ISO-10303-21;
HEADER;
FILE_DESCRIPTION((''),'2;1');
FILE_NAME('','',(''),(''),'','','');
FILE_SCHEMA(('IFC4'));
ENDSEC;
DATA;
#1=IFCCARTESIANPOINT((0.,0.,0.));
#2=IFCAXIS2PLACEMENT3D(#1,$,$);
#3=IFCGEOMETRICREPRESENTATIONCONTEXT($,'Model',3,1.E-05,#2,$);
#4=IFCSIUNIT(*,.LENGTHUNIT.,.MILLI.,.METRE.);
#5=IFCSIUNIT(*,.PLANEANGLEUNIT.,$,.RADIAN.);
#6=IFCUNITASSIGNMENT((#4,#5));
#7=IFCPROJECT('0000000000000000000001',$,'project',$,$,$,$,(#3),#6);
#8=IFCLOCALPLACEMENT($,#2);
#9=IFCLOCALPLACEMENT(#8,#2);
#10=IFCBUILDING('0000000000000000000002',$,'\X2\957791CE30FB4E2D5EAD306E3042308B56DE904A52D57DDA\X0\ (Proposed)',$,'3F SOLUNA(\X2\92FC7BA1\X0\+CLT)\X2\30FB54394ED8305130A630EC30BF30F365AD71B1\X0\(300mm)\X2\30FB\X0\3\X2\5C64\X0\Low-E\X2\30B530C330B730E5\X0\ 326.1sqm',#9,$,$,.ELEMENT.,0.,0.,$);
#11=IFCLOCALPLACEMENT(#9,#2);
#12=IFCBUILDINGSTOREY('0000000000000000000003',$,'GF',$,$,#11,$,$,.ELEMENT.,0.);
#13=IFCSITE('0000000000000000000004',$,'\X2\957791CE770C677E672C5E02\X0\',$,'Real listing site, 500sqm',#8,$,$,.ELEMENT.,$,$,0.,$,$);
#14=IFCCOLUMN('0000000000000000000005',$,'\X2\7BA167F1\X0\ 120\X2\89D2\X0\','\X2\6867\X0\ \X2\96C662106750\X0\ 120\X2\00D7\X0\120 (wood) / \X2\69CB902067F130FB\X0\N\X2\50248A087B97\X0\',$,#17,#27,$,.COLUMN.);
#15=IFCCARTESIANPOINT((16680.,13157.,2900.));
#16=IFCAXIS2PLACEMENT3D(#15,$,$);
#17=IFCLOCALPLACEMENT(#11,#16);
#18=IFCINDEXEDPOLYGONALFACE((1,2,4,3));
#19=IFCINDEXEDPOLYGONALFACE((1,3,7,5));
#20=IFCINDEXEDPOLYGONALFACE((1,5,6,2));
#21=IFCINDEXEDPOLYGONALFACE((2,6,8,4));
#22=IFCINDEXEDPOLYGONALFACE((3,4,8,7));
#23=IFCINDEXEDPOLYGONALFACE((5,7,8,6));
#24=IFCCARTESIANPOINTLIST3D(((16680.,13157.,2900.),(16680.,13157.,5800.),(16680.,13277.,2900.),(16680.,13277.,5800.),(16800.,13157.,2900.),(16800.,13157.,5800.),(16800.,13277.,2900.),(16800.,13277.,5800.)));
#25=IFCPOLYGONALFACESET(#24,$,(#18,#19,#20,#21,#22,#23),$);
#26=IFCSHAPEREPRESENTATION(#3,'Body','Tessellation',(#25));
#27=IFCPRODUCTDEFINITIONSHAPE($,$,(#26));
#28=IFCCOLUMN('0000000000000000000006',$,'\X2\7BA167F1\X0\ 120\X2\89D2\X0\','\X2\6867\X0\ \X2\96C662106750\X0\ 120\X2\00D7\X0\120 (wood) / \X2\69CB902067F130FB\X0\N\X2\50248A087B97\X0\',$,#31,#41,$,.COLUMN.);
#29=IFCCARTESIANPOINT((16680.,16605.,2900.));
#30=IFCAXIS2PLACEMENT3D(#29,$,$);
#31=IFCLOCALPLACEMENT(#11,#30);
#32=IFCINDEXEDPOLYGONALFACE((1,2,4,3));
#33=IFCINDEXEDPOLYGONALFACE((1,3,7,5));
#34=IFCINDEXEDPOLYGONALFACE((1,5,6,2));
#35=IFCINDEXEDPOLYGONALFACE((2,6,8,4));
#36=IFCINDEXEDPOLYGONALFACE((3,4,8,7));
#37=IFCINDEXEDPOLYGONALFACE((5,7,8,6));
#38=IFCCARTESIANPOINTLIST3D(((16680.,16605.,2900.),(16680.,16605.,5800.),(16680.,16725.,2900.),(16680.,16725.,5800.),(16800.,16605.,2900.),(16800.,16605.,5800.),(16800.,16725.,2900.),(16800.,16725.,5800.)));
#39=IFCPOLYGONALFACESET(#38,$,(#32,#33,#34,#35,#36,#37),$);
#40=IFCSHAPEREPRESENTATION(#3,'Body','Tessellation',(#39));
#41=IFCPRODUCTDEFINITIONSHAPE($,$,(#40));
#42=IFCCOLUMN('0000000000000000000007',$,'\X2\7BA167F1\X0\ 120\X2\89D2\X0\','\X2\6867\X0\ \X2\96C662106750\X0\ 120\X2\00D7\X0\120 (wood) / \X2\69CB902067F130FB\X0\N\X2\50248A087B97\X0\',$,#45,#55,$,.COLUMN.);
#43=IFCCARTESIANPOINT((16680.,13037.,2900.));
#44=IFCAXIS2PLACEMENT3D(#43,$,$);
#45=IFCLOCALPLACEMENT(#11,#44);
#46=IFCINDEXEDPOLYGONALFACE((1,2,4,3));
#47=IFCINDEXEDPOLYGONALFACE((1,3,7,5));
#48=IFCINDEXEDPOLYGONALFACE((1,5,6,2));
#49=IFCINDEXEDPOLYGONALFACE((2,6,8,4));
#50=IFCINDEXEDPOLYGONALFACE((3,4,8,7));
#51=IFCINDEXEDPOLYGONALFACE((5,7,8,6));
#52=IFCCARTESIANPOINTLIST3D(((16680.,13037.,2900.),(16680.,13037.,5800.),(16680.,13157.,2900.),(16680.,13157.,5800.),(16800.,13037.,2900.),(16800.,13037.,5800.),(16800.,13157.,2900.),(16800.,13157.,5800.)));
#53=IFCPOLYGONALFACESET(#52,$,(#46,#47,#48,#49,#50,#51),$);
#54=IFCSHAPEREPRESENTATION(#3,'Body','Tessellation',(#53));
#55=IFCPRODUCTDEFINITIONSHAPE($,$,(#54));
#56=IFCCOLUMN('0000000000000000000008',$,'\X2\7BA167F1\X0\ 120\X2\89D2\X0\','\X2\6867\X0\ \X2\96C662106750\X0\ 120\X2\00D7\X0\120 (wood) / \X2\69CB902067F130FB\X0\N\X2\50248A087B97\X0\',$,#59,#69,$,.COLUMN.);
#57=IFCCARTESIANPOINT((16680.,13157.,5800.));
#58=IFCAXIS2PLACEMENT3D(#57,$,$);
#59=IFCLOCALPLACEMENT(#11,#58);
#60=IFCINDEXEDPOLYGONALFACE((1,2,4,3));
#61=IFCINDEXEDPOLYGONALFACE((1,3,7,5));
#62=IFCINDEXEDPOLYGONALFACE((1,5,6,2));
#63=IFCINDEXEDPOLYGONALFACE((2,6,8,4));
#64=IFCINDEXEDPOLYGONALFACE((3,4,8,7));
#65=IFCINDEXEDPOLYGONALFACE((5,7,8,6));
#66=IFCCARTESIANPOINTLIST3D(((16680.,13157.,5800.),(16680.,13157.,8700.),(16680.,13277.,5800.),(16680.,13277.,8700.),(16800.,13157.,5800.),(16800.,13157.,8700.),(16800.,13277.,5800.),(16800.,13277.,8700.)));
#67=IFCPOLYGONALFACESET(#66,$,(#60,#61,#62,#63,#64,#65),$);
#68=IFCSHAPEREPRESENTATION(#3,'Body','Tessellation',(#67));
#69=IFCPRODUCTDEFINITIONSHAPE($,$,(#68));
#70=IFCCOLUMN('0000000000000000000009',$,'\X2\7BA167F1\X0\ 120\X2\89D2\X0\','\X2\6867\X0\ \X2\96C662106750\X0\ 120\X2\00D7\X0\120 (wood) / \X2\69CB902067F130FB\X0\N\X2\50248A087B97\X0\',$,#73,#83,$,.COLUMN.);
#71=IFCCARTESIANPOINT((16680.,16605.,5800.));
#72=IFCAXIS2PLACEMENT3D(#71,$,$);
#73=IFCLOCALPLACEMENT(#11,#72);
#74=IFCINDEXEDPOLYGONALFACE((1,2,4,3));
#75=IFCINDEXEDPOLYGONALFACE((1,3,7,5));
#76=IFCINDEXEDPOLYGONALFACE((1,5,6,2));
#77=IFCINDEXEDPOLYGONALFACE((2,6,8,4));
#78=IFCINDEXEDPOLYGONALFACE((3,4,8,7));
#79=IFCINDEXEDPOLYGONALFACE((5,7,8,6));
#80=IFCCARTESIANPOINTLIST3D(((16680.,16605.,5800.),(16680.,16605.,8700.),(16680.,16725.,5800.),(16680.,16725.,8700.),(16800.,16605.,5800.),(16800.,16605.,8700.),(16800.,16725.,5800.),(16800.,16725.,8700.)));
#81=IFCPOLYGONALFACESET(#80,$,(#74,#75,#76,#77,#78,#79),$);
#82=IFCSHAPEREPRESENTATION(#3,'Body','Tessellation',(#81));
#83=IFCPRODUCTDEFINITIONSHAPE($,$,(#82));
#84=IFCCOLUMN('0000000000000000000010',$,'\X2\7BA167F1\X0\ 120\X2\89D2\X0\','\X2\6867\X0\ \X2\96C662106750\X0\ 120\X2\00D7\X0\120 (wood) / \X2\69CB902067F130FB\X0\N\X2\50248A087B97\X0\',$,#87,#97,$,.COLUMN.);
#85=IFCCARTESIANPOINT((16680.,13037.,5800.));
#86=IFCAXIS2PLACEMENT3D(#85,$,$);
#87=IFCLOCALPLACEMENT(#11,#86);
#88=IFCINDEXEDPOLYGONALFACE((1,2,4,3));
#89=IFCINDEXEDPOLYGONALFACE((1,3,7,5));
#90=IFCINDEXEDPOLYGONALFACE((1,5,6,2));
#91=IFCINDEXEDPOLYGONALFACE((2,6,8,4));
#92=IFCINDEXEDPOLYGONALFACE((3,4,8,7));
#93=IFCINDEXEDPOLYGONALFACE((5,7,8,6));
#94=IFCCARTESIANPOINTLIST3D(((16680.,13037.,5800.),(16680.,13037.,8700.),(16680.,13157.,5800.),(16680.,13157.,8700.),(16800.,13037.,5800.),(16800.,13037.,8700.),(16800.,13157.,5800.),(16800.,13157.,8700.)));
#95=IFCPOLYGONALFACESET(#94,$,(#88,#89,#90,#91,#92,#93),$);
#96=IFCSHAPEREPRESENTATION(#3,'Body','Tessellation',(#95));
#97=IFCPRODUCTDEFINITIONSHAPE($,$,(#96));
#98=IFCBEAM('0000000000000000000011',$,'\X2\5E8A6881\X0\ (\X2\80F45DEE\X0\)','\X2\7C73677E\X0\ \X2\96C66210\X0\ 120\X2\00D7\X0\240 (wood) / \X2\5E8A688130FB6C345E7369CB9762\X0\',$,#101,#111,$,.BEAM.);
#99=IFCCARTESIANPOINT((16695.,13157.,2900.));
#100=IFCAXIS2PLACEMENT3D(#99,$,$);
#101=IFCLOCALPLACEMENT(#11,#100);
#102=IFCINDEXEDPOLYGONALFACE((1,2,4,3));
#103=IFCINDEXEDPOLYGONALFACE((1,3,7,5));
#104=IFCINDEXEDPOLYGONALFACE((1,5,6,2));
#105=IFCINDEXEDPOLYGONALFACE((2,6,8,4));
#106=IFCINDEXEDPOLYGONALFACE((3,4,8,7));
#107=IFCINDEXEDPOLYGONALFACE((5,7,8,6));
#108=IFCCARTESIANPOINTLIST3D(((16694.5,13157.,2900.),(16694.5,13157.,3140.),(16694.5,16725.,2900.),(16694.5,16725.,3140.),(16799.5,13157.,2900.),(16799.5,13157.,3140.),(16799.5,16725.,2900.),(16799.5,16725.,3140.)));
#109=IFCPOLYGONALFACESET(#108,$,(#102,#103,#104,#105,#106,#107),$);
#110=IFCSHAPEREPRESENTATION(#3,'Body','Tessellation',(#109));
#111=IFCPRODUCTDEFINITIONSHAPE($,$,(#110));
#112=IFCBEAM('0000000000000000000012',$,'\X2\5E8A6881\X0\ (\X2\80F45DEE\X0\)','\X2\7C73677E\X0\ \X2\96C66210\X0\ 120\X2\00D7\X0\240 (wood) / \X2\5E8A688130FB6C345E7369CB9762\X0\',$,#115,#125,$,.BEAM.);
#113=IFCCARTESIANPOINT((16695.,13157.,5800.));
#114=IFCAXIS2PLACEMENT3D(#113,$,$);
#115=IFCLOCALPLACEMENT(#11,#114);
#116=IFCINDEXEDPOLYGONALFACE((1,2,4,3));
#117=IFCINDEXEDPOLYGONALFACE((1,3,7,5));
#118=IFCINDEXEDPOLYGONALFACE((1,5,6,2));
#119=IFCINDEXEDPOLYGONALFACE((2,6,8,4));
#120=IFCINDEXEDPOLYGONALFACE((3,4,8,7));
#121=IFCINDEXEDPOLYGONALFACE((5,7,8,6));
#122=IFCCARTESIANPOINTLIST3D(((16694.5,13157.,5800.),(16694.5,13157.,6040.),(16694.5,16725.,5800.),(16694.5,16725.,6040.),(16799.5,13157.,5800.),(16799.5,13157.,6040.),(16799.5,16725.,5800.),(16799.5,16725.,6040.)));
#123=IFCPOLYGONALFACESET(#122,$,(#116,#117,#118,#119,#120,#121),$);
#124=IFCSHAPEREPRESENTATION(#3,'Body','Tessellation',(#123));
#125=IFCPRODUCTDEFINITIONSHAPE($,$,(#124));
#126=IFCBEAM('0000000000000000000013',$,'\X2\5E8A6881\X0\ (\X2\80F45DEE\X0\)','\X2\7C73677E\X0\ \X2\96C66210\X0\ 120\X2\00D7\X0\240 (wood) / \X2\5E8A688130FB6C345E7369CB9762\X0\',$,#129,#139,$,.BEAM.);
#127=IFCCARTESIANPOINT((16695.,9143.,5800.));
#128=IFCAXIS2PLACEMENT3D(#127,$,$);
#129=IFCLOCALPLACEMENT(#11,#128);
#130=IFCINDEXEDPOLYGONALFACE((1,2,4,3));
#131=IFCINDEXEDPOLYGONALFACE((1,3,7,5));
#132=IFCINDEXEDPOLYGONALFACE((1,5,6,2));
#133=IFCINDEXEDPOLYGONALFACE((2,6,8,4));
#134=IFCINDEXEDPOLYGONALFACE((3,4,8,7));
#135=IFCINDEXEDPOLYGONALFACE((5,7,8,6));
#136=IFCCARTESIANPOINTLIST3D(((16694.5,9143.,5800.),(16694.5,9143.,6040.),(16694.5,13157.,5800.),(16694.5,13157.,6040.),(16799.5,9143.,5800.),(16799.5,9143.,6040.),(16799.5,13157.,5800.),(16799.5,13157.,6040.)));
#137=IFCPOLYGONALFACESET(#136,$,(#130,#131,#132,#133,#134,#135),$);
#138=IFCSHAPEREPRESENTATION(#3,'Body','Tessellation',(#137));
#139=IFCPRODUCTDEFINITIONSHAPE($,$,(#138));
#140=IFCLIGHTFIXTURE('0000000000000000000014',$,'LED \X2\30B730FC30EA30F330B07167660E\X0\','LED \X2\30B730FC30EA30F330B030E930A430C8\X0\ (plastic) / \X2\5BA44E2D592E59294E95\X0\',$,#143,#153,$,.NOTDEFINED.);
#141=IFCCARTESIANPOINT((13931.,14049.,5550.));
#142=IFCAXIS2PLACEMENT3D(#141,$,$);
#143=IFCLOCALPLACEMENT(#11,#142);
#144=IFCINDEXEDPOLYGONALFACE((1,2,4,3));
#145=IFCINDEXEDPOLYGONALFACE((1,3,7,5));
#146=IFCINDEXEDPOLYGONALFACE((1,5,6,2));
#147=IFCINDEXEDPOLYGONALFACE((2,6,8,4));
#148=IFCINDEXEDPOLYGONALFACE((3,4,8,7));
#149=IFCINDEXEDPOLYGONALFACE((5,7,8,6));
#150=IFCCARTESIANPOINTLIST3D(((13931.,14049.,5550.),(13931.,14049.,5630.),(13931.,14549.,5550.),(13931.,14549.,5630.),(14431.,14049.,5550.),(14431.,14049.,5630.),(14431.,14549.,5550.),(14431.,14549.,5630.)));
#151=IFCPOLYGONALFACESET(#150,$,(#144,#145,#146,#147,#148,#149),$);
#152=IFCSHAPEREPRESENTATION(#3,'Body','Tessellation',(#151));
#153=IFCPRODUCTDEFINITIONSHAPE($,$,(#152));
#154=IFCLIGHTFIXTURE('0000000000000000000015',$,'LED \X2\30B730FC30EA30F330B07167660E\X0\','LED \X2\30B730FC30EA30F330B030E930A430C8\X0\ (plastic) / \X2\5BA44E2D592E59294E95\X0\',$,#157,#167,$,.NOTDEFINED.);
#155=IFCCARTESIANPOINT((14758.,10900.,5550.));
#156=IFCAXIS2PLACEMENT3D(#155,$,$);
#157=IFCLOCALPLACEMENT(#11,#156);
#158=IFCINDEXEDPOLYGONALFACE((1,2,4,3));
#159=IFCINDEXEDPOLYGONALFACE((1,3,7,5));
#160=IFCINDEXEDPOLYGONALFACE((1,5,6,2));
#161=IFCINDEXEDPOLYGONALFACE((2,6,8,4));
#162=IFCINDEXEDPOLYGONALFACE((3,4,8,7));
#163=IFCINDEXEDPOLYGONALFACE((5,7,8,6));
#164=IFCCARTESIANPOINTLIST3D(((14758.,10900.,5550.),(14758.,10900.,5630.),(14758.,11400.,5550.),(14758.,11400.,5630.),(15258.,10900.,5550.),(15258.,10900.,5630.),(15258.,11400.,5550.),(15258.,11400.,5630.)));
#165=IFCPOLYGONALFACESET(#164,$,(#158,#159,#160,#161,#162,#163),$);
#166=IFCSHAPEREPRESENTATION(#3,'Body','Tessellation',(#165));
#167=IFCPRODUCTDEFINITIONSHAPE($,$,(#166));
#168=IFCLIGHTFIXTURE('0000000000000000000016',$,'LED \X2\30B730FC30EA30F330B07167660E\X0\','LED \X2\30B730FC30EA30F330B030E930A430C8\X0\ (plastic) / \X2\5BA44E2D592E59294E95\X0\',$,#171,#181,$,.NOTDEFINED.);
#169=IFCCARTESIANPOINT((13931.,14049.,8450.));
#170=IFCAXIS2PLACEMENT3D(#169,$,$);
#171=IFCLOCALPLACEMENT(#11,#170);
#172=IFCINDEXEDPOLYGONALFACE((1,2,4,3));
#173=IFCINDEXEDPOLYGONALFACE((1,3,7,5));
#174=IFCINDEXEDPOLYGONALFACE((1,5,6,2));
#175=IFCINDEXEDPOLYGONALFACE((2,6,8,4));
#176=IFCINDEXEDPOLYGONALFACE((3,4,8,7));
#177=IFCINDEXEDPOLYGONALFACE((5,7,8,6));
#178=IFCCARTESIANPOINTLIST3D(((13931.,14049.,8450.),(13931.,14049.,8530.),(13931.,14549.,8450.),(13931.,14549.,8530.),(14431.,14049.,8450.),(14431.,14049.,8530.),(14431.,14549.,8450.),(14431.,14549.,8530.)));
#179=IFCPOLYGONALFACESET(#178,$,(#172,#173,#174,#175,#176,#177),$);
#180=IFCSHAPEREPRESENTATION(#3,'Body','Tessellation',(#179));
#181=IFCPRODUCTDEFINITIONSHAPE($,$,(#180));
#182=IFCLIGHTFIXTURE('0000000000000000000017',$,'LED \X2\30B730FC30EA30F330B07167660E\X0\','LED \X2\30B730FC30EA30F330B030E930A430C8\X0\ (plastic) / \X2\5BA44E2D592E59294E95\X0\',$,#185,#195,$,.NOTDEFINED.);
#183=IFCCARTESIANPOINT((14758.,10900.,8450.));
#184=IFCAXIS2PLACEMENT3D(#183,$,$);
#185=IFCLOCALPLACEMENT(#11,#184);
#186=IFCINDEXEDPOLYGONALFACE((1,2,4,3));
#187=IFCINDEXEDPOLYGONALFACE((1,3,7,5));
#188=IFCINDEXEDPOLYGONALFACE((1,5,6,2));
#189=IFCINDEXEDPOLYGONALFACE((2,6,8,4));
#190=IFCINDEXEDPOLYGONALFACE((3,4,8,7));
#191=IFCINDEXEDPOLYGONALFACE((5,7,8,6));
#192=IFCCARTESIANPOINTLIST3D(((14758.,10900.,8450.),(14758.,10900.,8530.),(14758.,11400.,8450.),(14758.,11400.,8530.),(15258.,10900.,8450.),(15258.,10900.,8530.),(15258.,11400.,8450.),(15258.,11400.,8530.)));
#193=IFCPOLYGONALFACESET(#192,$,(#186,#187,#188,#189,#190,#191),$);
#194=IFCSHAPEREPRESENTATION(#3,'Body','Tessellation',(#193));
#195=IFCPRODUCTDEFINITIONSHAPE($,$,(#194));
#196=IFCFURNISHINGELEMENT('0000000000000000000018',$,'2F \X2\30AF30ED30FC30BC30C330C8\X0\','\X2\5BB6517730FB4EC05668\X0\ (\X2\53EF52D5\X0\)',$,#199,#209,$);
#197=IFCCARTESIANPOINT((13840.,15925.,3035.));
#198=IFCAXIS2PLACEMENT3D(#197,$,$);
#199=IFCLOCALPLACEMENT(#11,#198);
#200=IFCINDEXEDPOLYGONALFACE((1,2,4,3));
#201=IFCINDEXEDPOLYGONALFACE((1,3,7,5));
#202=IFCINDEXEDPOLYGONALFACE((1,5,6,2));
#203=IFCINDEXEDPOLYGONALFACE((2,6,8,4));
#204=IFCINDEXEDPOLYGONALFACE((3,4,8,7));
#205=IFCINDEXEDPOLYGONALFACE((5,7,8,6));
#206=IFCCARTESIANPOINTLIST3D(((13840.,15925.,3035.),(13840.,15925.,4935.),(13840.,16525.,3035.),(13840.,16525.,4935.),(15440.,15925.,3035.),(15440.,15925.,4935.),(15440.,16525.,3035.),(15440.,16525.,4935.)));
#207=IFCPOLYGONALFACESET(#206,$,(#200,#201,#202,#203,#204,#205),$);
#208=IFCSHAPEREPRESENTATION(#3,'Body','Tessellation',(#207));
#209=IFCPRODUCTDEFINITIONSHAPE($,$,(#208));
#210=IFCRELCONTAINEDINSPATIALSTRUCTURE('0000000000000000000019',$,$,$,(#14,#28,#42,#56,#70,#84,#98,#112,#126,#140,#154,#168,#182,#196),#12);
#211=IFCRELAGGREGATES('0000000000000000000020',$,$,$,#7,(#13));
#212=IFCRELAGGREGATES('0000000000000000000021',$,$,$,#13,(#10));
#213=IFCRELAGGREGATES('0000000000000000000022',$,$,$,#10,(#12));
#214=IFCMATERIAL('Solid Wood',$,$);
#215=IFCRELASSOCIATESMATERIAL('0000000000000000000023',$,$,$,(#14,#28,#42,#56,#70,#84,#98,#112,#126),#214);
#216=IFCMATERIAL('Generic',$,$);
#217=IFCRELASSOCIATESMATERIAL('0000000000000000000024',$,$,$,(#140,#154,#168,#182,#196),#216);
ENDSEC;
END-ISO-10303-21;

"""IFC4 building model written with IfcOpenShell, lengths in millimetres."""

from ifc_helpers import new_model, si_unit, frame, frame_2d, origin, place, context, project, spatial, rectangle, extrude, material, element, save


model = new_model("IFC4")

# Units and contexts
model_context = context("Model", 3, precision=1e-05, world=origin())
ifc_project = project(units=[si_unit("LENGTHUNIT", "METRE", prefix="MILLI"), si_unit("PLANEANGLEUNIT", "RADIAN")], contexts=[model_context])

# Site, building, storey
site_placement = place(None, origin())
site = spatial("IfcSite", under=ifc_project, at=site_placement, Name="長野県松本市", ObjectType="Real listing site, 500sqm", CompositionType="ELEMENT", RefElevation=0.0)
building_placement = place(site_placement, origin())
building = spatial("IfcBuilding", under=site, at=building_placement, Name="長野・中庭のある回遊動線 (Proposed)", ObjectType="3F SOLUNA(鋼管+CLT)・吹付けウレタン断熱(300mm)・3層Low-Eサッシュ 326.1sqm", CompositionType="ELEMENT", ElevationOfRefHeight=0.0, ElevationOfTerrain=0.0)
storey_placement = place(building_placement, origin())
storey = spatial("IfcBuildingStorey", under=building, at=storey_placement, Name="GF", CompositionType="ELEMENT", Elevation=0.0)

# Columns
ifc_material_1 = material(Name="Solid Wood")
column_1_placement = place(storey_placement, frame((16680.0, 13157.0, 2900.0)))
element("IfcColumn", 1, at=column_1_placement, inside=storey, material=ifc_material_1, Name="管柱 120角", Description="桧 集成材 120×120 (wood) / 構造柱・N値計算", PredefinedType="COLUMN", context=model_context, shape_type="SweptSolid", body=[
    extrude(rectangle(XDim=120.0, YDim=120.0, at=frame_2d((60.0, 60.0))), frame((16680.0, 13157.0, 2900.0)), (0.0, 0.0, 1.0), 2900.0),
])
column_2_placement = place(storey_placement, frame((16680.0, 16605.0, 2900.0)))
element("IfcColumn", 2, at=column_2_placement, inside=storey, material=ifc_material_1, Name="管柱 120角", Description="桧 集成材 120×120 (wood) / 構造柱・N値計算", PredefinedType="COLUMN", context=model_context, shape_type="SweptSolid", body=[
    extrude(rectangle(XDim=120.0, YDim=120.0, at=frame_2d((60.0, 60.0))), frame((16680.0, 16605.0, 2900.0)), (0.0, 0.0, 1.0), 2900.0),
])
column_3_placement = place(storey_placement, frame((16680.0, 13037.0, 2900.0)))
element("IfcColumn", 3, at=column_3_placement, inside=storey, material=ifc_material_1, Name="管柱 120角", Description="桧 集成材 120×120 (wood) / 構造柱・N値計算", PredefinedType="COLUMN", context=model_context, shape_type="SweptSolid", body=[
    extrude(rectangle(XDim=120.0, YDim=120.0, at=frame_2d((60.0, 60.0))), frame((16680.0, 13037.0, 2900.0)), (0.0, 0.0, 1.0), 2900.0),
])
column_4_placement = place(storey_placement, frame((16680.0, 13157.0, 5800.0)))
element("IfcColumn", 4, at=column_4_placement, inside=storey, material=ifc_material_1, Name="管柱 120角", Description="桧 集成材 120×120 (wood) / 構造柱・N値計算", PredefinedType="COLUMN", context=model_context, shape_type="SweptSolid", body=[
    extrude(rectangle(XDim=120.0, YDim=120.0, at=frame_2d((60.0, 60.0))), frame((16680.0, 13157.0, 5800.0)), (0.0, 0.0, 1.0), 2900.0),
])
column_5_placement = place(storey_placement, frame((16680.0, 16605.0, 5800.0)))
element("IfcColumn", 5, at=column_5_placement, inside=storey, material=ifc_material_1, Name="管柱 120角", Description="桧 集成材 120×120 (wood) / 構造柱・N値計算", PredefinedType="COLUMN", context=model_context, shape_type="SweptSolid", body=[
    extrude(rectangle(XDim=120.0, YDim=120.0, at=frame_2d((60.0, 60.0))), frame((16680.0, 16605.0, 5800.0)), (0.0, 0.0, 1.0), 2900.0),
])
column_6_placement = place(storey_placement, frame((16680.0, 13037.0, 5800.0)))
element("IfcColumn", 6, at=column_6_placement, inside=storey, material=ifc_material_1, Name="管柱 120角", Description="桧 集成材 120×120 (wood) / 構造柱・N値計算", PredefinedType="COLUMN", context=model_context, shape_type="SweptSolid", body=[
    extrude(rectangle(XDim=120.0, YDim=120.0, at=frame_2d((60.0, 60.0))), frame((16680.0, 13037.0, 5800.0)), (0.0, 0.0, 1.0), 2900.0),
])

# Beams
beam_1_placement = place(storey_placement, frame((16695.0, 13157.0, 2900.0)))
element("IfcBeam", 7, at=beam_1_placement, inside=storey, material=ifc_material_1, Name="床梁 (胴差)", Description="米松 集成 120×240 (wood) / 床梁・水平構面", PredefinedType="BEAM", context=model_context, shape_type="SweptSolid", body=[
    extrude(rectangle(XDim=105.0, YDim=3568.0, at=frame_2d((52.0, 1784.0))), frame((16695.0, 13157.0, 2900.0)), (0.0, 0.0, 1.0), 240.0),
])
beam_2_placement = place(storey_placement, frame((16695.0, 13157.0, 5800.0)))
element("IfcBeam", 8, at=beam_2_placement, inside=storey, material=ifc_material_1, Name="床梁 (胴差)", Description="米松 集成 120×240 (wood) / 床梁・水平構面", PredefinedType="BEAM", context=model_context, shape_type="SweptSolid", body=[
    extrude(rectangle(XDim=105.0, YDim=3568.0, at=frame_2d((52.0, 1784.0))), frame((16695.0, 13157.0, 5800.0)), (0.0, 0.0, 1.0), 240.0),
])
beam_3_placement = place(storey_placement, frame((16695.0, 9143.0, 5800.0)))
element("IfcBeam", 9, at=beam_3_placement, inside=storey, material=ifc_material_1, Name="床梁 (胴差)", Description="米松 集成 120×240 (wood) / 床梁・水平構面", PredefinedType="BEAM", context=model_context, shape_type="SweptSolid", body=[
    extrude(rectangle(XDim=105.0, YDim=4014.0, at=frame_2d((52.0, 2007.0))), frame((16695.0, 9143.0, 5800.0)), (0.0, 0.0, 1.0), 240.0),
])

# Light fixtures
ifc_material_2 = material(Name="Generic")
light_fixture_1_placement = place(storey_placement, frame((13931.0, 14049.0, 5550.0)))
element("IfcLightFixture", 10, at=light_fixture_1_placement, inside=storey, material=ifc_material_2, Name="LED シーリング照明", Description="LED シーリングライト (plastic) / 室中央天井", PredefinedType="NOTDEFINED", context=model_context, shape_type="SweptSolid", body=[
    extrude(rectangle(XDim=500.0, YDim=500.0, at=frame_2d((250.0, 250.0))), frame((13931.0, 14049.0, 5550.0)), (0.0, 0.0, 1.0), 80.0),
])
light_fixture_2_placement = place(storey_placement, frame((14758.0, 10900.0, 5550.0)))
element("IfcLightFixture", 11, at=light_fixture_2_placement, inside=storey, material=ifc_material_2, Name="LED シーリング照明", Description="LED シーリングライト (plastic) / 室中央天井", PredefinedType="NOTDEFINED", context=model_context, shape_type="SweptSolid", body=[
    extrude(rectangle(XDim=500.0, YDim=500.0, at=frame_2d((250.0, 250.0))), frame((14758.0, 10900.0, 5550.0)), (0.0, 0.0, 1.0), 80.0),
])
light_fixture_3_placement = place(storey_placement, frame((13931.0, 14049.0, 8450.0)))
element("IfcLightFixture", 12, at=light_fixture_3_placement, inside=storey, material=ifc_material_2, Name="LED シーリング照明", Description="LED シーリングライト (plastic) / 室中央天井", PredefinedType="NOTDEFINED", context=model_context, shape_type="SweptSolid", body=[
    extrude(rectangle(XDim=500.0, YDim=500.0, at=frame_2d((250.0, 250.0))), frame((13931.0, 14049.0, 8450.0)), (0.0, 0.0, 1.0), 80.0),
])
light_fixture_4_placement = place(storey_placement, frame((14758.0, 10900.0, 8450.0)))
element("IfcLightFixture", 13, at=light_fixture_4_placement, inside=storey, material=ifc_material_2, Name="LED シーリング照明", Description="LED シーリングライト (plastic) / 室中央天井", PredefinedType="NOTDEFINED", context=model_context, shape_type="SweptSolid", body=[
    extrude(rectangle(XDim=500.0, YDim=500.0, at=frame_2d((250.0, 250.0))), frame((14758.0, 10900.0, 8450.0)), (0.0, 0.0, 1.0), 80.0),
])

# Furnishing element
furnishing_1_placement = place(storey_placement, frame((13840.0, 15925.0, 3035.0)))
element("IfcFurnishingElement", 14, at=furnishing_1_placement, inside=storey, material=ifc_material_2, Name="2F クローゼット", Description="家具・什器 (可動)", context=model_context, shape_type="SweptSolid", body=[
    extrude(rectangle(XDim=1600.0, YDim=600.0, at=frame_2d((800.0, 300.0))), frame((13840.0, 15925.0, 3035.0)), (0.0, 0.0, 1.0), 1900.0),
])

save(model, "model.ifc")
